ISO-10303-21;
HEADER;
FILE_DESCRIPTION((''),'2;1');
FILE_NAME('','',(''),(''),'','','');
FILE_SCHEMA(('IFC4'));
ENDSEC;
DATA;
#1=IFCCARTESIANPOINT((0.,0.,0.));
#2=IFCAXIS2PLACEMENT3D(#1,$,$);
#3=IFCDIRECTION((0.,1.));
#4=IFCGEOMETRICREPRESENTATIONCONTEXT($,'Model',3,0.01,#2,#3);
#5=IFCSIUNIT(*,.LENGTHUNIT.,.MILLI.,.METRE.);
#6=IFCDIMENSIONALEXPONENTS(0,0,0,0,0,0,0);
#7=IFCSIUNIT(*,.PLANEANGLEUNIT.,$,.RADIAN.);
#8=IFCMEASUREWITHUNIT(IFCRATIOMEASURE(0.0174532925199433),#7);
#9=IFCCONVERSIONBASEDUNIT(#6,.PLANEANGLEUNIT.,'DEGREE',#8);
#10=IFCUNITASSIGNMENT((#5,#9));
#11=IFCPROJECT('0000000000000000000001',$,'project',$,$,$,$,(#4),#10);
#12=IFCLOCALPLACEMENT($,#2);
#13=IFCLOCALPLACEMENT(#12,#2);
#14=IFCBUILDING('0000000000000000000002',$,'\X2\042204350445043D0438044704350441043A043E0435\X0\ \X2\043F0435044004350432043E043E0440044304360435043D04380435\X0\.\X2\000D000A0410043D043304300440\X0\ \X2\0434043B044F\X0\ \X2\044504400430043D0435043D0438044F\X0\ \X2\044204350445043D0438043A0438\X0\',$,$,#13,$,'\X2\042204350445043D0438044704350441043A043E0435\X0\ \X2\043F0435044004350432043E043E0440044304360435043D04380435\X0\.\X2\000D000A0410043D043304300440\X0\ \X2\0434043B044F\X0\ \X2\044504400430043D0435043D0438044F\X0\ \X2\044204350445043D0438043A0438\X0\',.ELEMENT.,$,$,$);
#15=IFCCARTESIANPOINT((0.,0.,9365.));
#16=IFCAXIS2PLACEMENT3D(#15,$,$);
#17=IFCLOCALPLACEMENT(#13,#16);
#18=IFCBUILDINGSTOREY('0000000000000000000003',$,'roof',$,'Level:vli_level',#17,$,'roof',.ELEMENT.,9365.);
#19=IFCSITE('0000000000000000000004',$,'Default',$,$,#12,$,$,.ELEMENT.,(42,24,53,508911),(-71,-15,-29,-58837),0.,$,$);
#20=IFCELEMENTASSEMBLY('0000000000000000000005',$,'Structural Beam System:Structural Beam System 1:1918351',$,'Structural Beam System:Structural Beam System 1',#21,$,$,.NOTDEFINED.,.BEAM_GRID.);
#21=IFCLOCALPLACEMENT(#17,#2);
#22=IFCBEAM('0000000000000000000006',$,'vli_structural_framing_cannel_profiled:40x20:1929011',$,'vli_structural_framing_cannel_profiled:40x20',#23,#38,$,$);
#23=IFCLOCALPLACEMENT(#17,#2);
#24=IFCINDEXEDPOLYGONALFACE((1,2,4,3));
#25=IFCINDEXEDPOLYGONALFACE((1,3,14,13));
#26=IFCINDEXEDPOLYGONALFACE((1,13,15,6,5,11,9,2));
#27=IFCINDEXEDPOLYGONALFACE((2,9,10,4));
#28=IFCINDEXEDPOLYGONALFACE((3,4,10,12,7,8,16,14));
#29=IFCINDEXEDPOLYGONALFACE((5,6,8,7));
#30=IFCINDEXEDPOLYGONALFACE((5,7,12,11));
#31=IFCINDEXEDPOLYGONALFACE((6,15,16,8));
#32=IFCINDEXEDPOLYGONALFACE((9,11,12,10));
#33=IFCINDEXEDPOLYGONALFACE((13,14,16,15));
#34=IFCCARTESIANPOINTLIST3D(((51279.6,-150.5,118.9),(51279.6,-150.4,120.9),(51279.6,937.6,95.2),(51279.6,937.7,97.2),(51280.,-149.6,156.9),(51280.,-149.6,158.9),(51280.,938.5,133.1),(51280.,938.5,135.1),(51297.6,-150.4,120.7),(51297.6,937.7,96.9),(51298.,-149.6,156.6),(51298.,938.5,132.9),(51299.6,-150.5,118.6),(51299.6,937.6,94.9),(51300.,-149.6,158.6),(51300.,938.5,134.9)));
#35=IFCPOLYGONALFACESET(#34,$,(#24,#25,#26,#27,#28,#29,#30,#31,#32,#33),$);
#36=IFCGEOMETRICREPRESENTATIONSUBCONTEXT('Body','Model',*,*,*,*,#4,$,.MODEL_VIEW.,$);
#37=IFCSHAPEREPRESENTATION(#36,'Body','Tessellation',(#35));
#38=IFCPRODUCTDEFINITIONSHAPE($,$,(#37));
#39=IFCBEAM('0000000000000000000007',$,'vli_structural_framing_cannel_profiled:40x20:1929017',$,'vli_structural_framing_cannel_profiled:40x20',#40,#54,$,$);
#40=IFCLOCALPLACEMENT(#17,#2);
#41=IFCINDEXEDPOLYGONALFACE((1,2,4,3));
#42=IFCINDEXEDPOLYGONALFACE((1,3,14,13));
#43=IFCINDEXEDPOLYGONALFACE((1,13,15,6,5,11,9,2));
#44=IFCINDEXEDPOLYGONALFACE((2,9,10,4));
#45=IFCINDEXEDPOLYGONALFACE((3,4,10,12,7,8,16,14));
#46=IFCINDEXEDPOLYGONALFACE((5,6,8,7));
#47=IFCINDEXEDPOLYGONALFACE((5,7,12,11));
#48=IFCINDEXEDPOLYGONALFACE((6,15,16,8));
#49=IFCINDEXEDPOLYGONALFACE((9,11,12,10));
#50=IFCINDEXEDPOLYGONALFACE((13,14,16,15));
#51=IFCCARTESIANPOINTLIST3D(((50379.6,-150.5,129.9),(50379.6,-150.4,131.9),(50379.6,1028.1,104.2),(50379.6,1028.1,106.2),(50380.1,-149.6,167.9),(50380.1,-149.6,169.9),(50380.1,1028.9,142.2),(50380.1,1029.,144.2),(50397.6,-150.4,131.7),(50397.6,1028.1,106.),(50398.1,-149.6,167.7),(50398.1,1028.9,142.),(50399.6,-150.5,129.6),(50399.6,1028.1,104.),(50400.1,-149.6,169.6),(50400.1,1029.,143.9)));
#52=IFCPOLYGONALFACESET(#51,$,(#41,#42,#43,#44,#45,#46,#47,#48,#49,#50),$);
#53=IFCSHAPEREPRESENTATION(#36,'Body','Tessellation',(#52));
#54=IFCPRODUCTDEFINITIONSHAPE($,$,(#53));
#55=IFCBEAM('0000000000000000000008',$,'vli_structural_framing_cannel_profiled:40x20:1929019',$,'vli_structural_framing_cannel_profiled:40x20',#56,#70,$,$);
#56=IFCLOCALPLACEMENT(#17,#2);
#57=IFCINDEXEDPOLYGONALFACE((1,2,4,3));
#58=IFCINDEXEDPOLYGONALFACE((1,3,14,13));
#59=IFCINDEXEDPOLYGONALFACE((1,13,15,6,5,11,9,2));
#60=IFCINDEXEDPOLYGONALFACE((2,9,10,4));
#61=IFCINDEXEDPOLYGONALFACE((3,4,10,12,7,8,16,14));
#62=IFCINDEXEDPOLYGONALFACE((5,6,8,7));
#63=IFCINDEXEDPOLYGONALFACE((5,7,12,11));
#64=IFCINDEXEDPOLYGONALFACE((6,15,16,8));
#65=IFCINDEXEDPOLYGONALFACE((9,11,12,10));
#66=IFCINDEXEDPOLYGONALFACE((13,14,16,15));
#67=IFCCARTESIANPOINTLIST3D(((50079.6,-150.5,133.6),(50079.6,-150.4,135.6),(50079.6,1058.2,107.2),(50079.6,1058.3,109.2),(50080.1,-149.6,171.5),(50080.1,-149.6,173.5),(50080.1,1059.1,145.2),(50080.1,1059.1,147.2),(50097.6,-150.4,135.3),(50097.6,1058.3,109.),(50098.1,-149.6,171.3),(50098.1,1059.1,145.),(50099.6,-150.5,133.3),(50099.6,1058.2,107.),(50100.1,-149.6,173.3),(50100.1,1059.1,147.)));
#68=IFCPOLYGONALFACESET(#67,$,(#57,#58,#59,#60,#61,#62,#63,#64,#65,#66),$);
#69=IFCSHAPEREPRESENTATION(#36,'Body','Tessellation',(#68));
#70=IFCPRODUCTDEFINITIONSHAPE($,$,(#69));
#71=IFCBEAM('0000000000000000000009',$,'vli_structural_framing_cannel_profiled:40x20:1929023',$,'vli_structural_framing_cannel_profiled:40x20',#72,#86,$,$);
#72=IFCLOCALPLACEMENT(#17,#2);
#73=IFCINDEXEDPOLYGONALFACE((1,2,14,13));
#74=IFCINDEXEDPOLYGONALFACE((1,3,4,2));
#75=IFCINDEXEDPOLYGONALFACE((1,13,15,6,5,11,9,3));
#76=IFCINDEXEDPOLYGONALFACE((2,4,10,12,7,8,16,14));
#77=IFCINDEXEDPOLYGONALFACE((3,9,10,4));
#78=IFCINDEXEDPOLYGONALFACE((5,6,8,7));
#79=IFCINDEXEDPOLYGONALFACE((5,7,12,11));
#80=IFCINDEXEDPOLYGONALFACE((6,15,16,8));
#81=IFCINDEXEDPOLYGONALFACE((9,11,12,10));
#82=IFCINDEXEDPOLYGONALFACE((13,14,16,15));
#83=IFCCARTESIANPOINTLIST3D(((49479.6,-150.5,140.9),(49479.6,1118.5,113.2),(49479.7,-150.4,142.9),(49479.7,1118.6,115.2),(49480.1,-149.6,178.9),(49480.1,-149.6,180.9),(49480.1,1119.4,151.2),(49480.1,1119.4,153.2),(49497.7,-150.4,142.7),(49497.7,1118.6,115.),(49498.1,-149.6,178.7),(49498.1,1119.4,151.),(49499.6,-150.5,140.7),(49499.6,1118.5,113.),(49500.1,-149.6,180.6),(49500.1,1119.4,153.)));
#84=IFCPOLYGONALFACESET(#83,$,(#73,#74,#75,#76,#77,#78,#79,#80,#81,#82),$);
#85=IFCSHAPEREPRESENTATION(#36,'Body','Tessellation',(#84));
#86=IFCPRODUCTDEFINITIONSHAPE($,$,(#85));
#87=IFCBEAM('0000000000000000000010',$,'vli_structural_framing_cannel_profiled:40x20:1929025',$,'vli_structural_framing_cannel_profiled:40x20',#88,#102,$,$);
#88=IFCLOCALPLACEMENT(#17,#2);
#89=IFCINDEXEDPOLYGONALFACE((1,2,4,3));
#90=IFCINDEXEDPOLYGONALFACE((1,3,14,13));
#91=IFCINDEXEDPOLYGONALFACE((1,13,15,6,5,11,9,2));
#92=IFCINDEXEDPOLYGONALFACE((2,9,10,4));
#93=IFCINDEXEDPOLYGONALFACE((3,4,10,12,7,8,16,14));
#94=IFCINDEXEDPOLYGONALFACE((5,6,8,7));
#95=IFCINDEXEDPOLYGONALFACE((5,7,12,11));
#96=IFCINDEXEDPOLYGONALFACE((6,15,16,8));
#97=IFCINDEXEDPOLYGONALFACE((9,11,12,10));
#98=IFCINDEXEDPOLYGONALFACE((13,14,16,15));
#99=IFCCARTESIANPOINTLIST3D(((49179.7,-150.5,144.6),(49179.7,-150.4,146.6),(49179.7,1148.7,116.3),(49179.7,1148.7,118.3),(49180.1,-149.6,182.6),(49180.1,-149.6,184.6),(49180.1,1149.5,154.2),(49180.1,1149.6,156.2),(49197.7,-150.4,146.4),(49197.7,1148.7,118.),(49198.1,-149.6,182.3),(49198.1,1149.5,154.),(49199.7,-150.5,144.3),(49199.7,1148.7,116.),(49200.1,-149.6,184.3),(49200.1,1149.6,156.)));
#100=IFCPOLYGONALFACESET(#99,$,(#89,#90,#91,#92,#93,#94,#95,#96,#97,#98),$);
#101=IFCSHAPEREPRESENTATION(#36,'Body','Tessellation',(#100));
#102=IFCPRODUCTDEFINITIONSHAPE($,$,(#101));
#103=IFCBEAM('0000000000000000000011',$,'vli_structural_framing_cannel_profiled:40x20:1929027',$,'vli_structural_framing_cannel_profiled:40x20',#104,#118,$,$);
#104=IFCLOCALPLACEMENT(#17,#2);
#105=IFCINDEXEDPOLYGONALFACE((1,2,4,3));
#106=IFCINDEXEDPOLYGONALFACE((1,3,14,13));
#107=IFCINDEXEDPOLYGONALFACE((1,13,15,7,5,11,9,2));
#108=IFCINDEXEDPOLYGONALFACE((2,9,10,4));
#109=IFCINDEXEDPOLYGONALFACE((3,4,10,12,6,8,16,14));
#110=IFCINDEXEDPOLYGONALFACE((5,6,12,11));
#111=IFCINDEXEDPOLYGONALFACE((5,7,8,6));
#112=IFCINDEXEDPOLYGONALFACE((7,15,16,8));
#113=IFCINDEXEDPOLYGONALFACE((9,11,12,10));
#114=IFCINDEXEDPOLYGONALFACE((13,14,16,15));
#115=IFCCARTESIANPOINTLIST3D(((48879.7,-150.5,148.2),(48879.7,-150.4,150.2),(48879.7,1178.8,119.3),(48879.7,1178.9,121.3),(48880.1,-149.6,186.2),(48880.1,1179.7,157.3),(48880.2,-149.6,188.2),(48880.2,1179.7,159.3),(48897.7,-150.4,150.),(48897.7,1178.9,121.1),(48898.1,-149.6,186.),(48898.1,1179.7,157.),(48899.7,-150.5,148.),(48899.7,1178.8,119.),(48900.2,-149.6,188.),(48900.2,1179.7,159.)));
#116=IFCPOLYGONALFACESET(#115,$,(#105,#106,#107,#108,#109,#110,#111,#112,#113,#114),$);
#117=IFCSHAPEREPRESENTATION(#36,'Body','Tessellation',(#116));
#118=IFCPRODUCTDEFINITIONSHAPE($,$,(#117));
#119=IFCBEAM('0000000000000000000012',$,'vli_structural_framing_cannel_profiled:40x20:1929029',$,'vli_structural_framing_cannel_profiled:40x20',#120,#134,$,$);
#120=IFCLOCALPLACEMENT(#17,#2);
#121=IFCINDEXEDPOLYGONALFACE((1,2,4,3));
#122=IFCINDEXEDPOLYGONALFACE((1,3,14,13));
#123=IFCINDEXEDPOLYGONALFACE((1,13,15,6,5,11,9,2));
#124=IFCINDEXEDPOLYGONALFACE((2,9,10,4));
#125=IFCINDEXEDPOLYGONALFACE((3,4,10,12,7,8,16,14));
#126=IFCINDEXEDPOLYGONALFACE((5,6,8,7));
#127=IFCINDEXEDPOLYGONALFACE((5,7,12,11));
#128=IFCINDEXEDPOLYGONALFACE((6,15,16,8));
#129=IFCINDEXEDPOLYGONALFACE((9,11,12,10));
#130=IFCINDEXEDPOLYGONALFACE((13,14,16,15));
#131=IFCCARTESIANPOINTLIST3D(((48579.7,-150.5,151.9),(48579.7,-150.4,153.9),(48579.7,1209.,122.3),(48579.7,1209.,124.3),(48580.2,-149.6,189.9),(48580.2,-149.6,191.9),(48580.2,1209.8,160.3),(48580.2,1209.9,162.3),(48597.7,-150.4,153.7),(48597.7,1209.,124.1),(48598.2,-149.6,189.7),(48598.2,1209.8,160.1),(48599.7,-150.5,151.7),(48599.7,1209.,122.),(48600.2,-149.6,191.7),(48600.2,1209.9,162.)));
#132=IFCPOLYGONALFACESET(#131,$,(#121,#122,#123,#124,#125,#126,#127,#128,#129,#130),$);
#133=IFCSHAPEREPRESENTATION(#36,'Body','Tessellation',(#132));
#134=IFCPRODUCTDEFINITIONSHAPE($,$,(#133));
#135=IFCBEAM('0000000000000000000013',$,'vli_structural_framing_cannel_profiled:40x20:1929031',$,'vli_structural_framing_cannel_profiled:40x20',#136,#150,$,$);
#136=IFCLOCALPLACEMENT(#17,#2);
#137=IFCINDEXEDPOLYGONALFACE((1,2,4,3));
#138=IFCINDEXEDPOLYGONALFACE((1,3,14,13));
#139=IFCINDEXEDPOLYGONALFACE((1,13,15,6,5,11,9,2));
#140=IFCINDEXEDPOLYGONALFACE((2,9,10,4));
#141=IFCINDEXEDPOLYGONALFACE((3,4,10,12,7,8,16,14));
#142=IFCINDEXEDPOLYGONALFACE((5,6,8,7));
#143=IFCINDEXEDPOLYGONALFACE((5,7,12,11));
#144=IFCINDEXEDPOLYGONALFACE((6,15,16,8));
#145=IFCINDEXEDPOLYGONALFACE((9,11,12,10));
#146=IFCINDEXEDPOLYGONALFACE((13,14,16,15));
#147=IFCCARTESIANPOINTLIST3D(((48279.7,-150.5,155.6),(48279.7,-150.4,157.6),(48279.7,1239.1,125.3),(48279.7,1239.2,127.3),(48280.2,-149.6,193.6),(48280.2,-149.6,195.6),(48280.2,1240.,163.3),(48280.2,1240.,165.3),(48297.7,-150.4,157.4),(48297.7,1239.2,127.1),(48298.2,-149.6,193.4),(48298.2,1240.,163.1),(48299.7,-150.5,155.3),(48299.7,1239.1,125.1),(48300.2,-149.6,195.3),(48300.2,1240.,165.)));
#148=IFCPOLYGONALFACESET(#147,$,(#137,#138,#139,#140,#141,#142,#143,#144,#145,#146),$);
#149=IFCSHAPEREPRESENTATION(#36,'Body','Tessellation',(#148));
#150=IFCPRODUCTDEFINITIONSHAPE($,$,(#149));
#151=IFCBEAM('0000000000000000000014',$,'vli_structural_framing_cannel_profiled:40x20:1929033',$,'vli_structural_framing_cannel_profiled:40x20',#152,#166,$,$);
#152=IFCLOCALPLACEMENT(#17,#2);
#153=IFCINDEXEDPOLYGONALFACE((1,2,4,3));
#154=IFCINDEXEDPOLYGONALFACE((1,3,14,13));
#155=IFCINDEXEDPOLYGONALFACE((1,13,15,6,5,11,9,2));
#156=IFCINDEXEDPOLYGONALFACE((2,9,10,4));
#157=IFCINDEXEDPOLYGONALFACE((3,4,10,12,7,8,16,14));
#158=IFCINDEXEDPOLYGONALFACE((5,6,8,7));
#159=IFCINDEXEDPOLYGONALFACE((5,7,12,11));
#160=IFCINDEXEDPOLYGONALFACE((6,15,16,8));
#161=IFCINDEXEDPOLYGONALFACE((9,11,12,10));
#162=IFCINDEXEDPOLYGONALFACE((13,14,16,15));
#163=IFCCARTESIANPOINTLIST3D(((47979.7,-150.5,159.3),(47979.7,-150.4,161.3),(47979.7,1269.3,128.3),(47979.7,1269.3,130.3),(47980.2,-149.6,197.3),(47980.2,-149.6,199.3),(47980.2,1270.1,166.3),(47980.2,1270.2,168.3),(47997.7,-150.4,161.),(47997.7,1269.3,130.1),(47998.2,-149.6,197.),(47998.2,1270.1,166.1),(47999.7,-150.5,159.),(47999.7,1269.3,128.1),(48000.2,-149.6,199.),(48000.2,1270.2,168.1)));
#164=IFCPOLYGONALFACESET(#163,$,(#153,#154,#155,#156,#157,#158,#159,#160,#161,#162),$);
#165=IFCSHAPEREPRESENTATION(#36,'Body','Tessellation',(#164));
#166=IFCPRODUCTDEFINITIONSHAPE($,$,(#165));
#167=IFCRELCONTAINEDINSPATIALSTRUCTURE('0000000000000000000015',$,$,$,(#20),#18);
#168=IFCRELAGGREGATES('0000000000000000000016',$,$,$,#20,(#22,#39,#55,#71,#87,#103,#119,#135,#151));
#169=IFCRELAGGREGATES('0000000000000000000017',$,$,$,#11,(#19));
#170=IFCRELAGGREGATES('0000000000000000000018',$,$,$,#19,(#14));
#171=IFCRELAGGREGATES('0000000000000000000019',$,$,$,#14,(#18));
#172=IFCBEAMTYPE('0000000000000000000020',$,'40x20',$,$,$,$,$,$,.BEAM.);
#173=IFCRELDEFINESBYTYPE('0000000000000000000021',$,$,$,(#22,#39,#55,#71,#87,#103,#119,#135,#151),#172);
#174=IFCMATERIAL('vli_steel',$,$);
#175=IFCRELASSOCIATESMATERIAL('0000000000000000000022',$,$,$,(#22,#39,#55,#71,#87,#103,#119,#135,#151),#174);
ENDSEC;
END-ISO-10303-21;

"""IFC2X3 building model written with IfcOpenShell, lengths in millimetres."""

from ifc_helpers import new_model, entity, si_unit, converted_unit, direction, frame, origin, place, context, subcontext, project, spatial, polyline, outline, extrude, material, type_object, element, aggregate, save


model = new_model("IFC2X3")

# Units and contexts
model_context = context("Model", 3, precision=0.01, world=origin(), true_north=direction((0.0, 1.0)))
body_context = subcontext(model_context, "Body", "Model", "MODEL_VIEW")
ifc_project = project(units=[si_unit("LENGTHUNIT", "METRE", prefix="MILLI"), converted_unit("PLANEANGLEUNIT", "DEGREE", entity("IfcRatioMeasure", 0.0174532925199433), si_unit("PLANEANGLEUNIT", "RADIAN"), dimensions=[0, 0, 0, 0, 0, 0, 0])], contexts=[model_context])

# Site, building, storey
site_placement = place(None, origin())
site = spatial("IfcSite", under=ifc_project, at=site_placement, Name="Default", CompositionType="ELEMENT", RefLatitude=(42, 24, 53, 508911), RefLongitude=(-71, -15, -29, -58837), RefElevation=0.0)
building_placement = place(site_placement, origin())
building = spatial("IfcBuilding", under=site, at=building_placement, Name="Техническое перевооружение.\r\nАнгар для хранения техники", LongName="Техническое перевооружение.\r\nАнгар для хранения техники", CompositionType="ELEMENT")
storey_placement = place(building_placement, frame((0.0, 0.0, 9365.0)))
storey = spatial("IfcBuildingStorey", under=building, at=storey_placement, Name="roof", ObjectType="Level:vli_level", LongName="roof", CompositionType="ELEMENT", Elevation=9365.0)

# Element assembly, beams
ifc_material = material(Name="vli_steel")
beam_type = type_object("IfcBeamType", Name="40x20", PredefinedType="BEAM")
assembly_1_placement = place(storey_placement, origin())
assembly_1 = element("IfcElementAssembly", 1, at=assembly_1_placement, inside=storey, Name="Structural Beam System:Structural Beam System 1:1918351", ObjectType="Structural Beam System:Structural Beam System 1", AssemblyPlace="NOTDEFINED", PredefinedType="BEAM_GRID")
beam_1_placement = place(assembly_1_placement, frame((51299.4, 939.2, 134.9), z_axis=(0.0, 0.02179, 0.999763), x_axis=(0.0, -0.999763, 0.02179)))
beam_1 = element("IfcBeam", 2, at=beam_1_placement, type_object=beam_type, material=ifc_material, Name="vli_structural_framing_cannel_profiled:40x20:1929011", ObjectType="vli_structural_framing_cannel_profiled:40x20", context=body_context, shape_type="SweptSolid", body=[
    extrude(outline(polyline([(-10.5, -20.0), (9.5, -20.0), (9.5, -18.0), (-8.5, -18.0), (-8.5, 18.0), (9.5, 18.0), (9.5, 20.0), (-10.5, 20.0), (-10.5, -20.0)])), frame((0.7, -10.1, -19.9), z_axis=(1.0, 0.0, 0.0), x_axis=(0.0, -0.999925, 0.012243)), (0.0, 0.0, 1.0), 1088.4),
])
beam_2_placement = place(assembly_1_placement, frame((50399.5, 1029.6, 143.9), z_axis=(0.0, 0.02179, 0.999763), x_axis=(0.0, -0.999763, 0.02179)))
beam_2 = element("IfcBeam", 3, at=beam_2_placement, type_object=beam_type, material=ifc_material, Name="vli_structural_framing_cannel_profiled:40x20:1929017", ObjectType="vli_structural_framing_cannel_profiled:40x20", context=body_context, shape_type="SweptSolid", body=[
    extrude(outline(polyline([(-10.5, -20.0), (9.5, -20.0), (9.5, -18.0), (-8.5, -18.0), (-8.5, 18.0), (9.5, 18.0), (9.5, 20.0), (-10.5, 20.0), (-10.5, -20.0)])), frame((0.7, -10.1, -19.9), z_axis=(1.0, 0.0, 0.0), x_axis=(0.0, -0.999925, 0.012243)), (0.0, 0.0, 1.0), 1178.8),
])
beam_3_placement = place(assembly_1_placement, frame((50099.5, 1059.8, 147.0), z_axis=(0.0, 0.02179, 0.999763), x_axis=(0.0, -0.999763, 0.02179)))
beam_3 = element("IfcBeam", 4, at=beam_3_placement, type_object=beam_type, material=ifc_material, Name="vli_structural_framing_cannel_profiled:40x20:1929019", ObjectType="vli_structural_framing_cannel_profiled:40x20", context=body_context, shape_type="SweptSolid", body=[
    extrude(outline(polyline([(-10.5, -20.0), (9.5, -20.0), (9.5, -18.0), (-8.5, -18.0), (-8.5, 18.0), (9.5, 18.0), (9.5, 20.0), (-10.5, 20.0), (-10.5, -20.0)])), frame((0.7, -10.1, -19.9), z_axis=(1.0, 0.0, 0.0), x_axis=(0.0, -0.999925, 0.012243)), (0.0, 0.0, 1.0), 1209.0),
])
beam_4_placement = place(assembly_1_placement, frame((49499.5, 1120.1, 153.0), z_axis=(0.0, 0.02179, 0.999763), x_axis=(0.0, -0.999763, 0.02179)))
beam_4 = element("IfcBeam", 5, at=beam_4_placement, type_object=beam_type, material=ifc_material, Name="vli_structural_framing_cannel_profiled:40x20:1929023", ObjectType="vli_structural_framing_cannel_profiled:40x20", context=body_context, shape_type="SweptSolid", body=[
    extrude(outline(polyline([(-10.5, -20.0), (9.5, -20.0), (9.5, -18.0), (-8.5, -18.0), (-8.5, 18.0), (9.5, 18.0), (9.5, 20.0), (-10.5, 20.0), (-10.5, -20.0)])), frame((0.7, -10.1, -19.9), z_axis=(1.0, 0.0, 0.0), x_axis=(0.0, -0.999925, 0.012243)), (0.0, 0.0, 1.0), 1269.3),
])
beam_5_placement = place(assembly_1_placement, frame((49199.5, 1150.2, 156.0), z_axis=(0.0, 0.02179, 0.999763), x_axis=(0.0, -0.999763, 0.02179)))
beam_5 = element("IfcBeam", 6, at=beam_5_placement, type_object=beam_type, material=ifc_material, Name="vli_structural_framing_cannel_profiled:40x20:1929025", ObjectType="vli_structural_framing_cannel_profiled:40x20", context=body_context, shape_type="SweptSolid", body=[
    extrude(outline(polyline([(-10.5, -20.0), (9.5, -20.0), (9.5, -18.0), (-8.5, -18.0), (-8.5, 18.0), (9.5, 18.0), (9.5, 20.0), (-10.5, 20.0), (-10.5, -20.0)])), frame((0.7, -10.1, -19.9), z_axis=(1.0, 0.0, 0.0), x_axis=(0.0, -0.999925, 0.012243)), (0.0, 0.0, 1.0), 1299.5),
])
beam_6_placement = place(assembly_1_placement, frame((48899.6, 1180.4, 159.0), z_axis=(0.0, 0.02179, 0.999763), x_axis=(0.0, -0.999763, 0.02179)))
beam_6 = element("IfcBeam", 7, at=beam_6_placement, type_object=beam_type, material=ifc_material, Name="vli_structural_framing_cannel_profiled:40x20:1929027", ObjectType="vli_structural_framing_cannel_profiled:40x20", context=body_context, shape_type="SweptSolid", body=[
    extrude(outline(polyline([(-10.5, -20.0), (9.5, -20.0), (9.5, -18.0), (-8.5, -18.0), (-8.5, 18.0), (9.5, 18.0), (9.5, 20.0), (-10.5, 20.0), (-10.5, -20.0)])), frame((0.7, -10.1, -19.9), z_axis=(1.0, 0.0, 0.0), x_axis=(0.0, -0.999925, 0.012243)), (0.0, 0.0, 1.0), 1329.6),
])
beam_7_placement = place(assembly_1_placement, frame((48599.6, 1210.5, 162.0), z_axis=(0.0, 0.02179, 0.999763), x_axis=(0.0, -0.999763, 0.02179)))
beam_7 = element("IfcBeam", 8, at=beam_7_placement, type_object=beam_type, material=ifc_material, Name="vli_structural_framing_cannel_profiled:40x20:1929029", ObjectType="vli_structural_framing_cannel_profiled:40x20", context=body_context, shape_type="SweptSolid", body=[
    extrude(outline(polyline([(-10.5, -20.0), (9.5, -20.0), (9.5, -18.0), (-8.5, -18.0), (-8.5, 18.0), (9.5, 18.0), (9.5, 20.0), (-10.5, 20.0), (-10.5, -20.0)])), frame((0.7, -10.1, -19.9), z_axis=(1.0, 0.0, 0.0), x_axis=(0.0, -0.999925, 0.012243)), (0.0, 0.0, 1.0), 1359.8),
])
beam_8_placement = place(assembly_1_placement, frame((48299.6, 1240.7, 165.0), z_axis=(0.0, 0.02179, 0.999763), x_axis=(0.0, -0.999763, 0.02179)))
beam_8 = element("IfcBeam", 9, at=beam_8_placement, type_object=beam_type, material=ifc_material, Name="vli_structural_framing_cannel_profiled:40x20:1929031", ObjectType="vli_structural_framing_cannel_profiled:40x20", context=body_context, shape_type="SweptSolid", body=[
    extrude(outline(polyline([(-10.5, -20.0), (9.5, -20.0), (9.5, -18.0), (-8.5, -18.0), (-8.5, 18.0), (9.5, 18.0), (9.5, 20.0), (-10.5, 20.0), (-10.5, -20.0)])), frame((0.7, -10.1, -19.9), z_axis=(1.0, 0.0, 0.0), x_axis=(0.0, -0.999925, 0.012243)), (0.0, 0.0, 1.0), 1389.9),
])
beam_9_placement = place(assembly_1_placement, frame((47999.6, 1270.8, 168.1), z_axis=(0.0, 0.02179, 0.999763), x_axis=(0.0, -0.999763, 0.02179)))
beam_9 = element("IfcBeam", 10, at=beam_9_placement, type_object=beam_type, material=ifc_material, Name="vli_structural_framing_cannel_profiled:40x20:1929033", ObjectType="vli_structural_framing_cannel_profiled:40x20", context=body_context, shape_type="SweptSolid", body=[
    extrude(outline(polyline([(-10.5, -20.0), (9.5, -20.0), (9.5, -18.0), (-8.5, -18.0), (-8.5, 18.0), (9.5, 18.0), (9.5, 20.0), (-10.5, 20.0), (-10.5, -20.0)])), frame((0.7, -10.1, -19.9), z_axis=(1.0, 0.0, 0.0), x_axis=(0.0, -0.999925, 0.012243)), (0.0, 0.0, 1.0), 1420.1),
])
aggregate(assembly_1, [beam_1, beam_2, beam_3, beam_4, beam_5, beam_6, beam_7, beam_8, beam_9])

save(model, "model.ifc")
